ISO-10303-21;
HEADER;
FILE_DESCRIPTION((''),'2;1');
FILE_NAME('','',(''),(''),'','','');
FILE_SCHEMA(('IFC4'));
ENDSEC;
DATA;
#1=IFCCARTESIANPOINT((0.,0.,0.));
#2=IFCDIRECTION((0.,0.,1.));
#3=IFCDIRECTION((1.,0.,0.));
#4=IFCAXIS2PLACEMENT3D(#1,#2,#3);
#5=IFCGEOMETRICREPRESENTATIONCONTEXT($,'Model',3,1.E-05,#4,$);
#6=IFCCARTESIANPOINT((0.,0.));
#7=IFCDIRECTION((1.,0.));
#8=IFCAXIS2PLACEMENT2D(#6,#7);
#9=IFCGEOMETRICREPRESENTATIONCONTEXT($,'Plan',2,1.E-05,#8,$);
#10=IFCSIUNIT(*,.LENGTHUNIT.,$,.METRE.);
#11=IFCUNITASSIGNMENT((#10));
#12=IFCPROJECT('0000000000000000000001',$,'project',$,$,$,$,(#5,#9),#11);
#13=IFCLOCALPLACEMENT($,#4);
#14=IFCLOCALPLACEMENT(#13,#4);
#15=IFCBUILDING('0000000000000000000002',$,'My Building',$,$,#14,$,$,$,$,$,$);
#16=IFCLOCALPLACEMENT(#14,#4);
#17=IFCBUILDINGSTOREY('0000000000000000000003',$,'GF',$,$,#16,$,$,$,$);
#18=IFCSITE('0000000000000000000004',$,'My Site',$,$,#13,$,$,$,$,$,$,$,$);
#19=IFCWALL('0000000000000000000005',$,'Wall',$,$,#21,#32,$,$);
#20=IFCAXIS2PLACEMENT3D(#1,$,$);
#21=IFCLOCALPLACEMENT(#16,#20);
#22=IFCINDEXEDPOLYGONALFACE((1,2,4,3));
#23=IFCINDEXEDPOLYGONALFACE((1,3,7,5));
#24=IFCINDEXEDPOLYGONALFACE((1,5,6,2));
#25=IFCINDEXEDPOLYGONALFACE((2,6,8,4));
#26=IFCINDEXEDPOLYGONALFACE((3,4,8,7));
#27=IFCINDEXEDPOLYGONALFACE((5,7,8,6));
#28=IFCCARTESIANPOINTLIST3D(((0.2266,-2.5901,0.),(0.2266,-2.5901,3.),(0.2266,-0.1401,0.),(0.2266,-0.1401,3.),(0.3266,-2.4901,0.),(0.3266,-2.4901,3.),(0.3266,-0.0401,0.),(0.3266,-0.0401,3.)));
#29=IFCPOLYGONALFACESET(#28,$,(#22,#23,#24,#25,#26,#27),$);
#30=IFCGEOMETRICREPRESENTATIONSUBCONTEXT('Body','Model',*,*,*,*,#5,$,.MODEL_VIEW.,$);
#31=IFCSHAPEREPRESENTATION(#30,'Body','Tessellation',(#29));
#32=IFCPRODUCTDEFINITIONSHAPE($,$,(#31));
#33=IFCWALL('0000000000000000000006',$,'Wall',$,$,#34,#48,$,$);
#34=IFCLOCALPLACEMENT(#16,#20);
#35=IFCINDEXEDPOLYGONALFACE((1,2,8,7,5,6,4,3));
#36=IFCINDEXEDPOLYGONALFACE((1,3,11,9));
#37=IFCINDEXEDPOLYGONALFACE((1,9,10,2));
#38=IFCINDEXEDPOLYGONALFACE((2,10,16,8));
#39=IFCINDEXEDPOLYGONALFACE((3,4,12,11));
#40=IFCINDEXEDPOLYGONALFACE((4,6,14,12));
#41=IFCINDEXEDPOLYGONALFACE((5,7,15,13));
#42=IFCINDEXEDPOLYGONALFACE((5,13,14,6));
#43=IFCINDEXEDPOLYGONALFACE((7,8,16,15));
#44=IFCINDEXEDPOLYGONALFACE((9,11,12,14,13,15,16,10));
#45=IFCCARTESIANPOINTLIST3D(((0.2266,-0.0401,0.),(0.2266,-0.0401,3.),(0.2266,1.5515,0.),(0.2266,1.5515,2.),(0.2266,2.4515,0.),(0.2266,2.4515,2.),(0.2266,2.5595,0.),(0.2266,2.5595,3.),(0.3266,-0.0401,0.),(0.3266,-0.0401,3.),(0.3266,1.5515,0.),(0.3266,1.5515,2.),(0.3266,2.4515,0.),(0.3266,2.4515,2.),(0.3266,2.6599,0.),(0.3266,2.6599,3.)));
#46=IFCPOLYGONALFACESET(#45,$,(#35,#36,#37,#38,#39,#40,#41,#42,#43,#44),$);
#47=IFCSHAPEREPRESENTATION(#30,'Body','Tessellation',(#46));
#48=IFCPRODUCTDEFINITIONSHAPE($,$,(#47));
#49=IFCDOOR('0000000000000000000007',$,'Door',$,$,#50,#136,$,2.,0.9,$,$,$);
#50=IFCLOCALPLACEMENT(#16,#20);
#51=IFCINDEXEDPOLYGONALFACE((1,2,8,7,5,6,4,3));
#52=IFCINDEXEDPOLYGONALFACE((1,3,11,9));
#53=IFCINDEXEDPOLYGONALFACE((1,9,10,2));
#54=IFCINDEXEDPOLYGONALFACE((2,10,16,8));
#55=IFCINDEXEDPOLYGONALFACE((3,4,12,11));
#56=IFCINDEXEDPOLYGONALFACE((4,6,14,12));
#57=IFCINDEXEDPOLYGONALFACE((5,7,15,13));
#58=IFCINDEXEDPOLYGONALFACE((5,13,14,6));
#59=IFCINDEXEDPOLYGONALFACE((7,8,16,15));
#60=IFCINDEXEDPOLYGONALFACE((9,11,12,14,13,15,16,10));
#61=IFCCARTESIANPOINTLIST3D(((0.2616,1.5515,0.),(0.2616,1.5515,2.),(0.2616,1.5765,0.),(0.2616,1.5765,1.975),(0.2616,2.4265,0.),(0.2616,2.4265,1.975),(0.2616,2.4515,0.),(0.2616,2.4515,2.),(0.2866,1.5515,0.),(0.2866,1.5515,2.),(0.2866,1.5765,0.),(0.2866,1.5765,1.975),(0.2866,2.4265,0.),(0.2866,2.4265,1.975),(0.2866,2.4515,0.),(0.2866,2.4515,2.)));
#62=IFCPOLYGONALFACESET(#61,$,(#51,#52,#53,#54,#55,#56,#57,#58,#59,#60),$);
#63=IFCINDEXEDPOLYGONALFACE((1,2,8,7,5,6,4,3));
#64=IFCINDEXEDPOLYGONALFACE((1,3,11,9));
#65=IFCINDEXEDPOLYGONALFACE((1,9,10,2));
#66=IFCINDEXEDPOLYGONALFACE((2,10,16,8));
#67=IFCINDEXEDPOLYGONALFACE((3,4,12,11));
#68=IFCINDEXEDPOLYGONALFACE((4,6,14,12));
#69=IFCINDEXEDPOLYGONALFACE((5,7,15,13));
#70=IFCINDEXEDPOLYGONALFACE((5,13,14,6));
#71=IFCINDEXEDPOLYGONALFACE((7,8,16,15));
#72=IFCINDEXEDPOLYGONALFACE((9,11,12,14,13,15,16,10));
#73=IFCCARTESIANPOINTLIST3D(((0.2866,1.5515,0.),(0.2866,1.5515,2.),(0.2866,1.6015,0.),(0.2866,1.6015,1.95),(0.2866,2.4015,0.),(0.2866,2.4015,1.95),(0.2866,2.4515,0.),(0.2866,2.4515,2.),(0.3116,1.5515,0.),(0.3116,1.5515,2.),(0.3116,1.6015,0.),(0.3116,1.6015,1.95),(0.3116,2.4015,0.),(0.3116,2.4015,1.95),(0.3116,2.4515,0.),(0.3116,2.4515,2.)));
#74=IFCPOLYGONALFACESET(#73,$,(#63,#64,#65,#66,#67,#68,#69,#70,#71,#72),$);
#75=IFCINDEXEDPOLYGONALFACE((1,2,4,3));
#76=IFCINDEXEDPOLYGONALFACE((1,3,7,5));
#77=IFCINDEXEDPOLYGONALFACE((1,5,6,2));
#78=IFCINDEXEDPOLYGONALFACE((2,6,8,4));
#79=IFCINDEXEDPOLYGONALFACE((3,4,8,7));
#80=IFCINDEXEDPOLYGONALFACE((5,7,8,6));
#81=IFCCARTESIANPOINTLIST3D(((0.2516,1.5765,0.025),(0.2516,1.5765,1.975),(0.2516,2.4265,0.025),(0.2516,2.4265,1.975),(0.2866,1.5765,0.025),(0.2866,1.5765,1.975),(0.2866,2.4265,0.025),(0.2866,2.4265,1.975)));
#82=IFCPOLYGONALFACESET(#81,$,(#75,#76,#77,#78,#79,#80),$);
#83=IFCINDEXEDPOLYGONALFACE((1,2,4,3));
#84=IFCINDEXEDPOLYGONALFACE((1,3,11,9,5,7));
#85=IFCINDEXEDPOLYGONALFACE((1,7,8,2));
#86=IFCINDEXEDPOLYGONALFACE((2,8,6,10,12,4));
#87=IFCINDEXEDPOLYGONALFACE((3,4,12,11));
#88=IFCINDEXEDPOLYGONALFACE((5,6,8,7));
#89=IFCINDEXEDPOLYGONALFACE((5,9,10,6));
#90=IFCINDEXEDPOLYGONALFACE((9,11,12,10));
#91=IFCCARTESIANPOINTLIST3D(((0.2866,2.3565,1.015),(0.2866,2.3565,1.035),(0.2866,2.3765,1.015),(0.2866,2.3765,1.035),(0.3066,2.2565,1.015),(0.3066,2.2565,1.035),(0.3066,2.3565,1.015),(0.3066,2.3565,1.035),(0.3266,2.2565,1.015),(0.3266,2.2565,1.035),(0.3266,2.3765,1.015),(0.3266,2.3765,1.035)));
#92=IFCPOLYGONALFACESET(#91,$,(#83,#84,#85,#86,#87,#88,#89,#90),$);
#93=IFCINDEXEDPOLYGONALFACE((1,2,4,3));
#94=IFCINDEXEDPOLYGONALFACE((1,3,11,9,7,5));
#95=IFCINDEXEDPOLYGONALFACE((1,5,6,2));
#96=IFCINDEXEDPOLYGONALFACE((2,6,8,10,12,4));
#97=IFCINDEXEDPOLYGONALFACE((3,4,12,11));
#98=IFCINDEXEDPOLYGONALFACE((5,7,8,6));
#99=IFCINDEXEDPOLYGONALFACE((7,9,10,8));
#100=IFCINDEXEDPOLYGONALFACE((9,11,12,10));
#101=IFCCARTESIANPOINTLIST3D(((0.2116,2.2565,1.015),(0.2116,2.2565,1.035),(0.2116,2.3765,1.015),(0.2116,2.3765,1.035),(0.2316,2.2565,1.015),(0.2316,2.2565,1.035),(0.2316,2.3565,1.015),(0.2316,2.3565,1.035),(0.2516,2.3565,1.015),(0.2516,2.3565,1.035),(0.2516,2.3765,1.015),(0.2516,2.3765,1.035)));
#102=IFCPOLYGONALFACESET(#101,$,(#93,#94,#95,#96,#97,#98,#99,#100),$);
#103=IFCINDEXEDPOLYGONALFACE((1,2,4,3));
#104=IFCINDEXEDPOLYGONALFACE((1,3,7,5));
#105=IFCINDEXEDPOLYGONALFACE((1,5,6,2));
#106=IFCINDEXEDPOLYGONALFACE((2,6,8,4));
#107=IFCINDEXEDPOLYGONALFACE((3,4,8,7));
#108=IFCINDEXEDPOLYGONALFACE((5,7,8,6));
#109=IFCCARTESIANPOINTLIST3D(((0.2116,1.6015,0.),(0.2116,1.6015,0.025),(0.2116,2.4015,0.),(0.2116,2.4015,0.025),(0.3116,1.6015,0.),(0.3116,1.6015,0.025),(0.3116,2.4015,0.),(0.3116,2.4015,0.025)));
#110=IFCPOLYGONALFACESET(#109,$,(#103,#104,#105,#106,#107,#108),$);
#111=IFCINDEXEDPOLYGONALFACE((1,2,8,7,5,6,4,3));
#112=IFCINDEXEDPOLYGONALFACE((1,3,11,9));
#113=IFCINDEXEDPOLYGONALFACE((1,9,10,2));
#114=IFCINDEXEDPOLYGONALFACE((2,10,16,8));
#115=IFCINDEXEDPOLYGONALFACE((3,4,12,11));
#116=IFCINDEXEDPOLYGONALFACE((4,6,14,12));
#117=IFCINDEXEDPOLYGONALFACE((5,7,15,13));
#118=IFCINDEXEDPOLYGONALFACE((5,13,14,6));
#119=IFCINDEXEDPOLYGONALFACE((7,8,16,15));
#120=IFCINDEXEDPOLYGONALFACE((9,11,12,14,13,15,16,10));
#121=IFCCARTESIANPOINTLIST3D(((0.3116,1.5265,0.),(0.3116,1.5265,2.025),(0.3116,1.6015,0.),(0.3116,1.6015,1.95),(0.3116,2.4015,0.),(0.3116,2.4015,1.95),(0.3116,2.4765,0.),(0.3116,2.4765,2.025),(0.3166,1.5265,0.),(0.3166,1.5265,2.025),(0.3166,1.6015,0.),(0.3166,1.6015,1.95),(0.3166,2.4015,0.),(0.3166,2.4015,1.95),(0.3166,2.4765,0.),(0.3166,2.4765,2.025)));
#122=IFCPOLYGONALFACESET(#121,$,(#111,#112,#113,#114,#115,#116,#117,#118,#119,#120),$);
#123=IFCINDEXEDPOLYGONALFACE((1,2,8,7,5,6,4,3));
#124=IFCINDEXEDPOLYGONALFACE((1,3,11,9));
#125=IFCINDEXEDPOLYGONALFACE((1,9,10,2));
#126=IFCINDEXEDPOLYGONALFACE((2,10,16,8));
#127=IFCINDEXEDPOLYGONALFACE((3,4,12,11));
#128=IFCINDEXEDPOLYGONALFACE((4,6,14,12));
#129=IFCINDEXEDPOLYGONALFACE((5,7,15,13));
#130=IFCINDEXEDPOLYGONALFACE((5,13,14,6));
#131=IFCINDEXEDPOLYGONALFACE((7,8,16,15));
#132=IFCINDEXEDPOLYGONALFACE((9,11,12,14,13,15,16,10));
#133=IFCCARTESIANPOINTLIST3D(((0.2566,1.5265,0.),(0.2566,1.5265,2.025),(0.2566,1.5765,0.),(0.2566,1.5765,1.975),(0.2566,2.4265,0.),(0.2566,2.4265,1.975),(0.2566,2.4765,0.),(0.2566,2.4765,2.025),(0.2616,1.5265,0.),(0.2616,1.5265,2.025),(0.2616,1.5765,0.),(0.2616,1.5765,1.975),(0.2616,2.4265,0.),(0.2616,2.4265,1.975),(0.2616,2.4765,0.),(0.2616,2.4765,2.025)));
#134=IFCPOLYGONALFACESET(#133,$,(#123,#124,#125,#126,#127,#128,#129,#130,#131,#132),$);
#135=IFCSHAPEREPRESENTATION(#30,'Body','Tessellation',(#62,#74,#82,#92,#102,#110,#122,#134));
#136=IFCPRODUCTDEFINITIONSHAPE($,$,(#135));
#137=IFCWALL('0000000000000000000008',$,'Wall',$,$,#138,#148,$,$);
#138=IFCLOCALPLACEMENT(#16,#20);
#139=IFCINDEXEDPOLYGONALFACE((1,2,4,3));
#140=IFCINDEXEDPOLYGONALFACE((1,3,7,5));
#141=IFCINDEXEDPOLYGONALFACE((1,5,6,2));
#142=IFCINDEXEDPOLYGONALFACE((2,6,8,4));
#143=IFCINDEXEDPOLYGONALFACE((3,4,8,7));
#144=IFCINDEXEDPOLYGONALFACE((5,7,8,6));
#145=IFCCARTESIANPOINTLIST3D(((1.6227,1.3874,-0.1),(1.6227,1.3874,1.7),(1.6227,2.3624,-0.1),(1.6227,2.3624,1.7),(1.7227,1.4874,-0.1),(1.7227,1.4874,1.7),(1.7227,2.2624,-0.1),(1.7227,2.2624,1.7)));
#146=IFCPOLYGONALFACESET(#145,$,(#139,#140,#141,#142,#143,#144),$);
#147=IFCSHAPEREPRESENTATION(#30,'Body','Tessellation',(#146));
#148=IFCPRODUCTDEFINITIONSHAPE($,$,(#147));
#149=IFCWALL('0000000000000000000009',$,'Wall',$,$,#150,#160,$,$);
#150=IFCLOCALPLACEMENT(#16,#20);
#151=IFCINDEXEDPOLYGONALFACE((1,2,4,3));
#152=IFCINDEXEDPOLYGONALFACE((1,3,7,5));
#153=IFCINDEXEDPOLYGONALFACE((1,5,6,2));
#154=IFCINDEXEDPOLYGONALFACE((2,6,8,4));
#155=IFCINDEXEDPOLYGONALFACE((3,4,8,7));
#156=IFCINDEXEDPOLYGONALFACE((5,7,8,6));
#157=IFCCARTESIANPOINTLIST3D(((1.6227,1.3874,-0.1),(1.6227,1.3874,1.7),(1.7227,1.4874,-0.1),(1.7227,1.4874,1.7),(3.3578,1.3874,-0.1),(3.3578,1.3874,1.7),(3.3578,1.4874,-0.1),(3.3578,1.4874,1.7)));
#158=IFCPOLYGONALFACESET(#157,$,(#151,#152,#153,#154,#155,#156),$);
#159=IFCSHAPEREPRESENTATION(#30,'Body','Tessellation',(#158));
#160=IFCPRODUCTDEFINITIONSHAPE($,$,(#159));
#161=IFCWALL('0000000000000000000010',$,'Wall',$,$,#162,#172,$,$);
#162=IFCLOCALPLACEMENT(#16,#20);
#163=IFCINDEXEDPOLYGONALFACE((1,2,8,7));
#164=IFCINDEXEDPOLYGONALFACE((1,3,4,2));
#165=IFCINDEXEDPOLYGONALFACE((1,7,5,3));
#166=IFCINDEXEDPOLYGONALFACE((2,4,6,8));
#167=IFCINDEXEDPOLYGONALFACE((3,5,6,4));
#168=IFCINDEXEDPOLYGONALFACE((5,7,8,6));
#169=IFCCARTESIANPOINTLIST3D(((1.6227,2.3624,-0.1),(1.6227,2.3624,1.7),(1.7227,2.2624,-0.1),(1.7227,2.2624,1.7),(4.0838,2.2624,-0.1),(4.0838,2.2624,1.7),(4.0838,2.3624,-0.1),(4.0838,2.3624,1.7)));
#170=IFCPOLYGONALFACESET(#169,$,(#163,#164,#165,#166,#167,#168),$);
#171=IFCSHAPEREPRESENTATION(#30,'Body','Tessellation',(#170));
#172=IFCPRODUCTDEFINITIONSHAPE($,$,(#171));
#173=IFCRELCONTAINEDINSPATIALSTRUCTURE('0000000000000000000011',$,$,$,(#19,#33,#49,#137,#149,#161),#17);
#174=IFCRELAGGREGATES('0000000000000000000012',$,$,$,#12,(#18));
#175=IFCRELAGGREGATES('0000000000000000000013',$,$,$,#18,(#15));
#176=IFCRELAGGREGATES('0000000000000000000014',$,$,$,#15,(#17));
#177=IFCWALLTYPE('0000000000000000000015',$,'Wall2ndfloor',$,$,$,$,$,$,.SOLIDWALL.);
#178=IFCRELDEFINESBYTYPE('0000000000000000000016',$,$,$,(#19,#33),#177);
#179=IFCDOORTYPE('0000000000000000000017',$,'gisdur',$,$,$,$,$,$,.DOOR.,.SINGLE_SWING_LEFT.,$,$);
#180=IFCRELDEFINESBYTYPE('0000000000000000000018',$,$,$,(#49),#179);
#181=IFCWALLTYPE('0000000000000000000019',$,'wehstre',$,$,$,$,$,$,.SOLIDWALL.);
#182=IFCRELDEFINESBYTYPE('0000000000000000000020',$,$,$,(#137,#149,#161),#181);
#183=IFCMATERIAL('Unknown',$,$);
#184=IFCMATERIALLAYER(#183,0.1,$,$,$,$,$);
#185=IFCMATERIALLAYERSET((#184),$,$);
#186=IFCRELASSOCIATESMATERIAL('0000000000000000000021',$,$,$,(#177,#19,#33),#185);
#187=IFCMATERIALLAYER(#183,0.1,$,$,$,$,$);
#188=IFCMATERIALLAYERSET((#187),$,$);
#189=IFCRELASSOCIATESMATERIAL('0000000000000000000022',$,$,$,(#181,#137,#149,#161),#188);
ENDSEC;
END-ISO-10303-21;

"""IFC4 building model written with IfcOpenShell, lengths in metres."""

from ifc_helpers import new_model, entity, si_unit, frame, origin_with_axes, origin_2d_with_axis, place, context, subcontext, project, spatial, line, indexed_curve, outline, extrude, shape, source, transform, mapped, material, layer, layer_set, layer_usage, type_object, type_shapes, element, fill, save


model = new_model("IFC4")

# Units and contexts
model_context = context("Model", 3, precision=1e-05, world=origin_with_axes())
plan_context = context("Plan", 2, precision=1e-05, world=origin_2d_with_axis())
body_context_1 = subcontext(model_context, "Body", "Model", "MODEL_VIEW")
body_context_2 = subcontext(plan_context, "Body", "Plan", "PLAN_VIEW")
ifc_project = project(units=[si_unit("LENGTHUNIT", "METRE")], contexts=[model_context, plan_context])

# Site, building, storey
site_placement = place(None, origin_with_axes())
site = spatial("IfcSite", under=ifc_project, at=site_placement, Name="My Site")
building_placement = place(site_placement, origin_with_axes())
building = spatial("IfcBuilding", under=site, at=building_placement, Name="My Building")
storey_placement = place(building_placement, origin_with_axes())
storey = spatial("IfcBuildingStorey", under=building, at=storey_placement, Name="GF")

# Shared definitions
ifc_material = material(Name="Unknown")

# Shared definitions
ifc_layer_1 = layer(ifc_material, 0.1)
ifc_layer_set_1 = layer_set([ifc_layer_1])
wall_type_1 = type_object("IfcWallType", Name="Wall2ndfloor", PredefinedType="SOLIDWALL", material=ifc_layer_set_1)

# Wall
ifc_layer_usage_1 = layer_usage(ifc_layer_set_1, "AXIS2", "POSITIVE", 0.0)
wall_1_placement = place(storey_placement, frame((0.2266, -0.1401, 0.0), z_axis=(0.0, 0.0, 1.0), x_axis=(0.0, -1.0, 0.0)))
element("IfcWall", 1, at=wall_1_placement, inside=storey, type_object=wall_type_1, material=ifc_layer_usage_1, Name="Wall", context=body_context_1, shape_type="SweptSolid", body=[
    extrude(outline(indexed_curve([(0.0, 0.0), (-0.1, 0.1), (2.35, 0.1), (2.45, 0.0)], segments=[line(1, 2, 3, 4, 1)])), origin_with_axes(), (0.0, 0.0, 1.0), 3.0),
])

# Wall, opening, door
ifc_layer_usage_2 = layer_usage(ifc_layer_set_1, "AXIS2", "POSITIVE", 0.0)
wall_2_placement = place(storey_placement, frame((0.3266, -0.0401, 0.0), z_axis=(0.0, 0.0, 1.0), x_axis=(0.0, 1.0, 0.0)))
wall_2 = element("IfcWall", 2, at=wall_2_placement, inside=storey, type_object=wall_type_1, material=ifc_layer_usage_2, Name="Wall", context=body_context_1, shape_type="SweptSolid", body=[
    extrude(outline(indexed_curve([(0.0, 0.0), (0.0, 0.1), (2.5996, 0.1), (2.7, 0.0)], segments=[line(1, 2, 3, 4, 1)])), origin_with_axes(), (0.0, 0.0, 1.0), 3.0),
])
shared_shape_1 = source(origin_with_axes(), body_context_1, "Body", "SweptSolid", [
    extrude(outline(indexed_curve([(0.0, 0.0), (0.9, 0.0), (0.9, 2.0), (0.0, 2.0)], segments=[line(1, 2, 3, 4, 1)])), frame((0.0, -0.6, 0.0), z_axis=(0.0, -1.0, 0.0), x_axis=(1.0, 0.0, 0.0)), (0.0, 0.0, -1.0), 1.2),
])
opening_1_placement = place(wall_2_placement, frame((1.5916, 0.015, 0.0), z_axis=(0.0, 0.0, 1.0), x_axis=(1.0, 0.0, 0.0)))
opening_1 = element("IfcOpeningElement", 3, at=opening_1_placement, cuts=wall_2, PredefinedType="OPENING", context=body_context_1, shape_type="MappedRepresentation", body=[
    mapped(shared_shape_1, transform((0.0, 0.0, 0.0), x_axis=(1.0, 0.0, 0.0), y_axis=(0.0, 1.0, 0.0), z_axis=(0.0, 0.0, 1.0), scale=1.0)),
])
door_type_1 = type_object("IfcDoorType", Name="gisdur", OperationType="SINGLE_SWING_LEFT", PredefinedType="DOOR")
shared_shape_2 = source(origin_with_axes(), body_context_1, "Body", "SweptSolid", [
    extrude(outline(indexed_curve([(0.0, 0.0), (0.0, 2.0), (0.9, 2.0), (0.9, 0.0), (0.875, 0.0), (0.875, 1.975), (0.025, 1.975), (0.025, 0.0)], segments=[line(1, 2, 3, 4, 5, 6, 7, 8, 1)])), frame((0.0, 0.025, 0.0), z_axis=(0.0, -1.0, 0.0), x_axis=(1.0, 0.0, 0.0)), (0.0, 0.0, -1.0), 0.025),
    extrude(outline(indexed_curve([(0.0, 0.0), (0.0, 2.0), (0.9, 2.0), (0.9, 0.0), (0.85, 0.0), (0.85, 1.95), (0.05, 1.95), (0.05, 0.0)], segments=[line(1, 2, 3, 4, 5, 6, 7, 8, 1)])), frame((0.0, 0.0, 0.0), z_axis=(0.0, -1.0, 0.0), x_axis=(1.0, 0.0, 0.0)), (0.0, 0.0, -1.0), 0.025),
    extrude(outline(indexed_curve([(0.0, 0.0), (0.85, 0.0), (0.85, 0.035), (0.0, 0.035)], segments=[line(1, 2, 3, 4, 1)])), frame((0.025, 0.025, 0.025), z_axis=(0.0, 0.0, 1.0), x_axis=(1.0, 0.0, 0.0)), (0.0, 0.0, 1.0), 1.95),
    extrude(outline(indexed_curve([(0.0, 0.0), (0.0, -0.04), (-0.12, -0.04), (-0.12, -0.02), (-0.02, -0.02), (-0.02, 0.0)], segments=[line(1, 2, 3, 4, 5, 6, 1)])), frame((0.825, 0.025, 1.015), z_axis=(0.0, 0.0, 1.0), x_axis=(1.0, 0.0, 0.0)), (0.0, 0.0, 1.0), 0.02),
    extrude(outline(indexed_curve([(0.0, 0.0), (0.0, 0.04), (-0.12, 0.04), (-0.12, 0.02), (-0.02, 0.02), (-0.02, 0.0)], segments=[line(1, 2, 3, 4, 5, 6, 1)])), frame((0.825, 0.06, 1.015), z_axis=(0.0, 0.0, 1.0), x_axis=(1.0, 0.0, 0.0)), (0.0, 0.0, 1.0), 0.02),
    extrude(outline(indexed_curve([(0.0, 0.0), (0.8, 0.0), (0.8, 0.1), (0.0, 0.1)], segments=[line(1, 2, 3, 4, 1)])), frame((0.05, 0.0, 0.0), z_axis=(0.0, 0.0, 1.0), x_axis=(1.0, 0.0, 0.0)), (0.0, 0.0, 1.0), 0.025),
    extrude(outline(indexed_curve([(0.0, 0.0), (0.0, 2.025), (0.95, 2.025), (0.95, 0.0), (0.875, 0.0), (0.875, 1.95), (0.075, 1.95), (0.075, 0.0)], segments=[line(1, 2, 3, 4, 5, 6, 7, 8, 1)])), frame((-0.025, -0.005, 0.0), z_axis=(0.0, -1.0, 0.0), x_axis=(1.0, 0.0, 0.0)), (0.0, 0.0, -1.0), 0.005),
    extrude(outline(indexed_curve([(0.0, 0.0), (0.0, 2.025), (0.95, 2.025), (0.95, 0.0), (0.9, 0.0), (0.9, 1.975), (0.05, 1.975), (0.05, 0.0)], segments=[line(1, 2, 3, 4, 5, 6, 7, 8, 1)])), frame((-0.025, 0.05, 0.0), z_axis=(0.0, -1.0, 0.0), x_axis=(1.0, 0.0, 0.0)), (0.0, 0.0, -1.0), 0.005),
])
shared_shape_3 = source(origin_with_axes(), body_context_2, "Body", "Curve2D", [
    entity("IfcIndexedPolyCurve", entity("IfcCartesianPointList2D", [[0.0, 0.0], [0.0, 0.05], [0.025, 0.05], [0.025, 0.025], [0.05, 0.025], [0.05, 0.0]]), [entity("IfcLineIndex", [1, 2, 3, 4, 5, 6, 1])]),
    entity("IfcIndexedPolyCurve", entity("IfcCartesianPointList2D", [[0.9, 0.0], [0.9, 0.05], [0.875, 0.05], [0.875, 0.025], [0.85, 0.025], [0.85, 0.0]]), [entity("IfcLineIndex", [1, 2, 3, 4, 5, 6, 1])]),
    entity("IfcTrimmedCurve", entity("IfcEllipse", entity("IfcAxis2Placement2D", entity("IfcCartesianPoint", [0.06, 0.05]), entity("IfcDirection", [1.0, 0.0])), 0.815, 0.85), [entity("IfcCartesianPoint", [0.875, 0.05])], [entity("IfcCartesianPoint", [0.06, 0.9])], True, "CARTESIAN"),
    entity("IfcIndexedPolyCurve", entity("IfcCartesianPointList2D", [[0.025, 0.05], [0.06, 0.05], [0.06, 0.9], [0.025, 0.9]]), [entity("IfcLineIndex", [1, 2, 3, 4, 1])]),
])
type_shapes(door_type_1, [shared_shape_2, shared_shape_3])
door_1_placement = place(opening_1_placement, frame((0.0, 0.0, 0.0), z_axis=(0.0, 0.0, 1.0), x_axis=(1.0, 0.0, 0.0)))
door_1 = element("IfcDoor", 4, at=door_1_placement, inside=storey, type_object=door_type_1, Name="Door", OverallHeight=2.0, OverallWidth=0.9, shapes=[
    shape(body_context_1, "Body", "MappedRepresentation", [mapped(shared_shape_2, transform((0.0, 0.0, 0.0), x_axis=(1.0, 0.0, 0.0), y_axis=(0.0, 1.0, 0.0), z_axis=(0.0, 0.0, 1.0), scale=1.0))]),
    shape(body_context_2, "Body", "MappedRepresentation", [mapped(shared_shape_3, transform((0.0, 0.0, 0.0), x_axis=(1.0, 0.0, 0.0), y_axis=(0.0, 1.0, 0.0), z_axis=(0.0, 0.0, 1.0), scale=1.0))]),
])
fill(opening_1, door_1)

# Walls
ifc_layer_2 = layer(ifc_material, 0.1)
ifc_layer_set_2 = layer_set([ifc_layer_2])
ifc_layer_usage_3 = layer_usage(ifc_layer_set_2, "AXIS2", "POSITIVE", 0.0)
wall_type_2 = type_object("IfcWallType", Name="wehstre", PredefinedType="SOLIDWALL", material=ifc_layer_set_2)
wall_3_placement = place(storey_placement, frame((1.6227, 2.2624, -0.1), z_axis=(0.0, 0.0, 1.0), x_axis=(0.0, -1.0, 0.0)))
element("IfcWall", 5, at=wall_3_placement, inside=storey, type_object=wall_type_2, material=ifc_layer_usage_3, Name="Wall", context=body_context_1, shape_type="SweptSolid", body=[
    extrude(outline(indexed_curve([(-0.1, 0.0), (0.0, 0.1), (0.775, 0.1), (0.875, 0.0)], segments=[line(1, 2, 3, 4, 1)])), origin_with_axes(), (0.0, 0.0, 1.0), 1.8),
])
ifc_layer_usage_4 = layer_usage(ifc_layer_set_2, "AXIS2", "POSITIVE", 0.0)
wall_4_placement = place(storey_placement, frame((1.6227, 1.3874, -0.1), z_axis=(0.0, 0.0, 1.0), x_axis=(1.0, 0.0, 0.0)))
element("IfcWall", 6, at=wall_4_placement, inside=storey, type_object=wall_type_2, material=ifc_layer_usage_4, Name="Wall", context=body_context_1, shape_type="SweptSolid", body=[
    extrude(outline(indexed_curve([(0.0, 0.0), (0.1, 0.1), (1.735, 0.1), (1.735, 0.0)], segments=[line(1, 2, 3, 4, 1)])), origin_with_axes(), (0.0, 0.0, 1.0), 1.8),
])
ifc_layer_usage_5 = layer_usage(ifc_layer_set_2, "AXIS2", "POSITIVE", 0.0)
wall_5_placement = place(storey_placement, frame((1.6227, 2.2624, -0.1), z_axis=(0.0, 0.0, 1.0), x_axis=(1.0, 0.0, 0.0)))
element("IfcWall", 7, at=wall_5_placement, inside=storey, type_object=wall_type_2, material=ifc_layer_usage_5, Name="Wall", context=body_context_1, shape_type="SweptSolid", body=[
    extrude(outline(indexed_curve([(0.1, 0.0), (0.0, 0.1), (2.461, 0.1), (2.461, 0.0)], segments=[line(1, 2, 3, 4, 1)])), origin_with_axes(), (0.0, 0.0, 1.0), 1.8),
])

save(model, "model.ifc")
